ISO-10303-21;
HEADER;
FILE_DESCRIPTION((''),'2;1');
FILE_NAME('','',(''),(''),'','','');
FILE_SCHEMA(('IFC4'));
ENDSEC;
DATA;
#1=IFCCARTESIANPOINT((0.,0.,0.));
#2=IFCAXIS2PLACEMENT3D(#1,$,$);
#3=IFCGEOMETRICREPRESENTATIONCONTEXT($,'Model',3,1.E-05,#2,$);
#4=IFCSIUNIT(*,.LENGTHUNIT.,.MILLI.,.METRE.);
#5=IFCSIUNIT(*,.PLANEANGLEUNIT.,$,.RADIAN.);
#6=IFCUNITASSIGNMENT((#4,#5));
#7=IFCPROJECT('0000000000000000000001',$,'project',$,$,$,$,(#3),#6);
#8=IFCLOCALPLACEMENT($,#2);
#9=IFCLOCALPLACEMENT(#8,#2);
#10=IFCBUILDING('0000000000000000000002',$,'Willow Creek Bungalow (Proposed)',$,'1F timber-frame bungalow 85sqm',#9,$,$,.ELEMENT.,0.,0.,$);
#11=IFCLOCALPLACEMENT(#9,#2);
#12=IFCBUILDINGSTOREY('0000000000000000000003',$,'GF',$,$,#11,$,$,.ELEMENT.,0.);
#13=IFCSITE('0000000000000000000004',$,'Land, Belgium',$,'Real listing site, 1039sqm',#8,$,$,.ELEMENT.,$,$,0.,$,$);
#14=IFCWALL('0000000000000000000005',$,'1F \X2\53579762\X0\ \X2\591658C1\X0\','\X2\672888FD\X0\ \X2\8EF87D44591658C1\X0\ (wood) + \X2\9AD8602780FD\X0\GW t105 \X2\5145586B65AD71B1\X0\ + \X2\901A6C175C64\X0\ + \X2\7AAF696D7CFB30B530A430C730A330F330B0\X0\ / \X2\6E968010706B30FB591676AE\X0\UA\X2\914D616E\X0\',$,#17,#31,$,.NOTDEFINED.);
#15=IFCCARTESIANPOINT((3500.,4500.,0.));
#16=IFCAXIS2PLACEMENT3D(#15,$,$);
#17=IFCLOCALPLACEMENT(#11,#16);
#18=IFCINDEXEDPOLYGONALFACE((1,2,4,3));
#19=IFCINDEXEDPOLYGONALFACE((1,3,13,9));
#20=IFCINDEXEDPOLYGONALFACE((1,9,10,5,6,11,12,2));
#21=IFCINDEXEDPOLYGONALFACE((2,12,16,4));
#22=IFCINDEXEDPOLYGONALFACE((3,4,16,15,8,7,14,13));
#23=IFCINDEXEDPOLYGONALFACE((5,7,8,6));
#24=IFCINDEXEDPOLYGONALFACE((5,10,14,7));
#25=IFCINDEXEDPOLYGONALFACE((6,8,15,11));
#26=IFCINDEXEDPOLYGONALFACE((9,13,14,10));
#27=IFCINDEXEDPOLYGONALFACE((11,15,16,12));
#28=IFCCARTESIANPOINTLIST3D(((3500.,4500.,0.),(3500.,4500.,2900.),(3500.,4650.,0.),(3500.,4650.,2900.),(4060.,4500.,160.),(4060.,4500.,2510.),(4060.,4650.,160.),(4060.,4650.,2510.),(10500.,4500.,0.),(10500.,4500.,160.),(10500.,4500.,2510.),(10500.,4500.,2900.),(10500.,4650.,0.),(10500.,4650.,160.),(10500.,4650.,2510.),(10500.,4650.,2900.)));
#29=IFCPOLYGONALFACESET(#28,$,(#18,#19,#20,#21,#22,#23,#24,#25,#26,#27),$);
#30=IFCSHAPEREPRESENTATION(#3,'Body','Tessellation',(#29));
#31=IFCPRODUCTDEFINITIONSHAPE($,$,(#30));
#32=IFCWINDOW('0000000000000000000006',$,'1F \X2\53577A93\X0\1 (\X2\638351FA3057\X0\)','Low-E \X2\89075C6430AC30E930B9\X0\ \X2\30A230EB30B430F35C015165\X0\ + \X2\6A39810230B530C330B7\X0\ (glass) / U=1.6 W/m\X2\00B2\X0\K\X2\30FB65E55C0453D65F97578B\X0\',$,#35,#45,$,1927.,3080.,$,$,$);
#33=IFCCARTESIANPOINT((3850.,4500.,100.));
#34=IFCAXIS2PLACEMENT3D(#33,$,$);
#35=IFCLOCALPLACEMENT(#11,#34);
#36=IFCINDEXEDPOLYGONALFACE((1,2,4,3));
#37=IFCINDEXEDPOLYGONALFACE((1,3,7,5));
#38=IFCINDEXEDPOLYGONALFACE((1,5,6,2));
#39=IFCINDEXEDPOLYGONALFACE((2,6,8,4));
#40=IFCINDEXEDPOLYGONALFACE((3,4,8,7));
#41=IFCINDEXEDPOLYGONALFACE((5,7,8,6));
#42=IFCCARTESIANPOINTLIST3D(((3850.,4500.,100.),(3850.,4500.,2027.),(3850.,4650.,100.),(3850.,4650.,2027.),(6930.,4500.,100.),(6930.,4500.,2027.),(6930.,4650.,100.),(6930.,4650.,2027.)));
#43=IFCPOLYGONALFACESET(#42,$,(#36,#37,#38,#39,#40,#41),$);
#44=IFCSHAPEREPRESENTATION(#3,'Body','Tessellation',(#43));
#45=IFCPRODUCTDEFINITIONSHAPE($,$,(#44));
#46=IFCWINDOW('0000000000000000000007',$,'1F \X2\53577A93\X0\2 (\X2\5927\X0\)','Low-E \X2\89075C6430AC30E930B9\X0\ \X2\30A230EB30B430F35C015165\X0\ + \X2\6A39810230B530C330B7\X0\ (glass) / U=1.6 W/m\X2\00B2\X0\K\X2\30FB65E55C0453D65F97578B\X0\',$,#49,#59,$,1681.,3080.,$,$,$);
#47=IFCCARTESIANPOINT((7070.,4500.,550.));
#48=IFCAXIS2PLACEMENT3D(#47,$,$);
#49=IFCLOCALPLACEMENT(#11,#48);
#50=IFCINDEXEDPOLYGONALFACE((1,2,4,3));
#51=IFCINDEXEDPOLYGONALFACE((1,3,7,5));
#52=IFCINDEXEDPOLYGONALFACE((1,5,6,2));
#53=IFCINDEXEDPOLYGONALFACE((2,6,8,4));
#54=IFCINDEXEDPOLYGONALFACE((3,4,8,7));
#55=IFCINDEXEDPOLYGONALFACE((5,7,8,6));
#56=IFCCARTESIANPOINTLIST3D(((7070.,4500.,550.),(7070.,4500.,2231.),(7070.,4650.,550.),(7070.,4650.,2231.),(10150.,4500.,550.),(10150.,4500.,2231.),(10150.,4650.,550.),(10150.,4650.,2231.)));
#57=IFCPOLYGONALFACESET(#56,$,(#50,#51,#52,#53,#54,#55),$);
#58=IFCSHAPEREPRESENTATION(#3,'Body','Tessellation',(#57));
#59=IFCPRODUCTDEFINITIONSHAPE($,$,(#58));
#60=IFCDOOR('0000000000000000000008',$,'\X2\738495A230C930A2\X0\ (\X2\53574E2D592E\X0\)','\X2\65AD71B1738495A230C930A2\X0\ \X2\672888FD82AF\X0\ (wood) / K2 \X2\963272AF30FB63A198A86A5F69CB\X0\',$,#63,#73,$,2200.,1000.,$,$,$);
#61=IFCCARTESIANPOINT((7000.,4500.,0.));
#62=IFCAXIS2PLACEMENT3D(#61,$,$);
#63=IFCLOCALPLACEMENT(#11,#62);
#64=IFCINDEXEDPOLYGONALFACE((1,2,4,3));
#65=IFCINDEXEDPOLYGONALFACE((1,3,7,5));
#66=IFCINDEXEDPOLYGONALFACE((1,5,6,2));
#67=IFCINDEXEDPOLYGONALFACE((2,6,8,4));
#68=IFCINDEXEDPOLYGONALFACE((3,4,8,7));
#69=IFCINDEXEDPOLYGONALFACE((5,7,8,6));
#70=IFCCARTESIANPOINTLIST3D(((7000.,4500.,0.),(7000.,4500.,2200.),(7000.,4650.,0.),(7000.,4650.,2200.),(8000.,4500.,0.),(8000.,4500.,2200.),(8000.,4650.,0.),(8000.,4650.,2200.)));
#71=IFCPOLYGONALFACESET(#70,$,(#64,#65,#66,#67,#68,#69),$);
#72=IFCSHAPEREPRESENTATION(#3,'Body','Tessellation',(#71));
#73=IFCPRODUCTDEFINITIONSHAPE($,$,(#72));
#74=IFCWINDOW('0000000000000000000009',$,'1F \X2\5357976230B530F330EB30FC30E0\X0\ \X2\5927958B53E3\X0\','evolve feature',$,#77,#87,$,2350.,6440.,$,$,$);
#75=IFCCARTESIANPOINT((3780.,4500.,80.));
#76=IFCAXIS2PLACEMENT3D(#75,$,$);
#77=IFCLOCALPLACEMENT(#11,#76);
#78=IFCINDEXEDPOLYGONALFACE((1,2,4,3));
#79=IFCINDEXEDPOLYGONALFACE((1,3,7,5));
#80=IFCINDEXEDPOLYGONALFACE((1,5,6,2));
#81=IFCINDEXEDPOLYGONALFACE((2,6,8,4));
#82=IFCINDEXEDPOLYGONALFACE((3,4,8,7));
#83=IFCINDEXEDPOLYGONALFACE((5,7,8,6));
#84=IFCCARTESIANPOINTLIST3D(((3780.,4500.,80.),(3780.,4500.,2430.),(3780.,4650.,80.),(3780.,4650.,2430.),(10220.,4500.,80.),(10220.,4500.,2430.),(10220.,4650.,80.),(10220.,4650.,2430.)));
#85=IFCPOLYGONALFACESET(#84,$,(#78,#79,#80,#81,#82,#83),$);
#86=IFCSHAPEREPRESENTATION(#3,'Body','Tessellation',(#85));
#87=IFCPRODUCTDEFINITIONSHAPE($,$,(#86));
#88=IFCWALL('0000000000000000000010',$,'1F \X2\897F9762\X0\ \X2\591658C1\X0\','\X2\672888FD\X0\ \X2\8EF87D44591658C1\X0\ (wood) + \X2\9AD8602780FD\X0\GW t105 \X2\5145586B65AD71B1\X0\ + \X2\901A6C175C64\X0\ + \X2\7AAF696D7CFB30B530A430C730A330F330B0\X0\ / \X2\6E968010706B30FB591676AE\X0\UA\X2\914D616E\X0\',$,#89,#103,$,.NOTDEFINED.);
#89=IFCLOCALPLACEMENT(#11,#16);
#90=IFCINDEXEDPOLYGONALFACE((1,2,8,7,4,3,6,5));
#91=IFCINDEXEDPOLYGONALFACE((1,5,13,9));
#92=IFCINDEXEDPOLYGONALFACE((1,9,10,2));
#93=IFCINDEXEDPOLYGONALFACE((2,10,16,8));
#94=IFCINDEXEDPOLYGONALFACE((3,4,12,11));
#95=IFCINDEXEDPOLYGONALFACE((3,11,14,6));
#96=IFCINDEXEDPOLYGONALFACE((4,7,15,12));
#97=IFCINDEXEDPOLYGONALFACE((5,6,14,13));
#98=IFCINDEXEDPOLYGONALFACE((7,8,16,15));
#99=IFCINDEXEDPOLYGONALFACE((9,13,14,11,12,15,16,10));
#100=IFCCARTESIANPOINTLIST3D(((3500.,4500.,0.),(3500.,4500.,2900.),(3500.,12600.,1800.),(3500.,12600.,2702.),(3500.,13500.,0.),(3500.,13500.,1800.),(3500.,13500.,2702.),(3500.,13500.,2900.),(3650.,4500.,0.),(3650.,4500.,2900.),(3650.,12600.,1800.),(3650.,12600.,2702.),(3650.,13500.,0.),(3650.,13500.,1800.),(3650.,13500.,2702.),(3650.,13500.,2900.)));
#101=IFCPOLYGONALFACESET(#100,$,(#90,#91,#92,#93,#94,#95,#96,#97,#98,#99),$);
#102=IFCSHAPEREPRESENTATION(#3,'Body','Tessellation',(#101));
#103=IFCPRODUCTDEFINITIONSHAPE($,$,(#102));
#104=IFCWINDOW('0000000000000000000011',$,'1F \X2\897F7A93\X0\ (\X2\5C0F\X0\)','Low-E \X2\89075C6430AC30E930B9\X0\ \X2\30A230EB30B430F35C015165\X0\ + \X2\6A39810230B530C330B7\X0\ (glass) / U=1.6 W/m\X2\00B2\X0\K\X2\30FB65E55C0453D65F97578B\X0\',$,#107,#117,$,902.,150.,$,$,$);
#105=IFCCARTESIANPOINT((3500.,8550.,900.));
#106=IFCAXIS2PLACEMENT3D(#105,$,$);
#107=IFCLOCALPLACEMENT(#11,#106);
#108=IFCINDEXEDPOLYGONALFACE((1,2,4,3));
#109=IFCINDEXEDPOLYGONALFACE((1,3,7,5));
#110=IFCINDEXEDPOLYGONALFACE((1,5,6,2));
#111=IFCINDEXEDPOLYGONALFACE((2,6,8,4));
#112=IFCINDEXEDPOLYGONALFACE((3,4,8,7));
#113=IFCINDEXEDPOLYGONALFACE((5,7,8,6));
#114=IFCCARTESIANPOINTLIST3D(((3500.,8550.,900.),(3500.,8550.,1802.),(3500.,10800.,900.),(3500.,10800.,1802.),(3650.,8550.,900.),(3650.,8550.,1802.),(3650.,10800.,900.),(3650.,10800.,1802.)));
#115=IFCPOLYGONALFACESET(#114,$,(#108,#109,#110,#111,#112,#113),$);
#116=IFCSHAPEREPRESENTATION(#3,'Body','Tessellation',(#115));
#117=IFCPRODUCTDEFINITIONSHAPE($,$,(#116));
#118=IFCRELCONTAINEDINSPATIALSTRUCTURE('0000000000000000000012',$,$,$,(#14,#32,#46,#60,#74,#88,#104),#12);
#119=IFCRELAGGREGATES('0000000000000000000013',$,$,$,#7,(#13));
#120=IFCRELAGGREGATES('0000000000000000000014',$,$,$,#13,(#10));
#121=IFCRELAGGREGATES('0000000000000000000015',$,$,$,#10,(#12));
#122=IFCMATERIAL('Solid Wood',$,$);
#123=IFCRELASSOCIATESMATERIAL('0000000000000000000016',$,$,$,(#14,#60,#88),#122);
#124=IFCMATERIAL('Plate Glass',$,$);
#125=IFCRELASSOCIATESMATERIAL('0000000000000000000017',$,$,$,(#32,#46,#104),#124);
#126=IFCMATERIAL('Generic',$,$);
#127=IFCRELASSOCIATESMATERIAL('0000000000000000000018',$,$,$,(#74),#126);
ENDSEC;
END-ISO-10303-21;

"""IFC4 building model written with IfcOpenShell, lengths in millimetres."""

from ifc_helpers import new_model, si_unit, frame, frame_2d, origin, place, context, project, spatial, rectangle, extrude, material, element, fill, save


model = new_model("IFC4")

# Units and contexts
model_context = context("Model", 3, precision=1e-05, world=origin())
ifc_project = project(units=[si_unit("LENGTHUNIT", "METRE", prefix="MILLI"), si_unit("PLANEANGLEUNIT", "RADIAN")], contexts=[model_context])

# Site, building, storey
site_placement = place(None, origin())
site = spatial("IfcSite", under=ifc_project, at=site_placement, Name="Land, Belgium", ObjectType="Real listing site, 1039sqm", CompositionType="ELEMENT", RefElevation=0.0)
building_placement = place(site_placement, origin())
building = spatial("IfcBuilding", under=site, at=building_placement, Name="Willow Creek Bungalow (Proposed)", ObjectType="1F timber-frame bungalow 85sqm", CompositionType="ELEMENT", ElevationOfRefHeight=0.0, ElevationOfTerrain=0.0)
storey_placement = place(building_placement, origin())
storey = spatial("IfcBuildingStorey", under=building, at=storey_placement, Name="GF", CompositionType="ELEMENT", Elevation=0.0)

# Shared definitions
ifc_material_1 = material(Name="Solid Wood")
ifc_material_2 = material(Name="Generic")

# Wall, openings, windows, door
wall_1_placement = place(storey_placement, frame((3500.0, 4500.0, 0.0)))
wall_1 = element("IfcWall", 1, at=wall_1_placement, inside=storey, material=ifc_material_1, Name="1F 南面 外壁", Description="木製 軸組外壁 (wood) + 高性能GW t105 充填断熱 + 通気層 + 窯業系サイディング / 準耐火・外皮UA配慮", PredefinedType="NOTDEFINED", context=model_context, shape_type="SweptSolid", body=[
    extrude(rectangle(XDim=7000.0, YDim=150.0, at=frame_2d((3500.0, 75.0))), frame((3500.0, 4500.0, 0.0)), (0.0, 0.0, 1.0), 2900.0),
])
opening_1_placement = place(storey_placement, frame((3850.0, 4500.0, 100.0)))
opening_1 = element("IfcOpeningElement", 2, at=opening_1_placement, cuts=wall_1, PredefinedType="NOTDEFINED", context=model_context, shape_type="SweptSolid", body=[
    extrude(rectangle(XDim=3080.0, YDim=150.0, at=frame_2d((1540.0, 75.0))), frame((3850.0, 4500.0, 100.0)), (0.0, 0.0, 1.0), 1927.0),
])
opening_2_placement = place(storey_placement, frame((7070.0, 4500.0, 550.0)))
opening_2 = element("IfcOpeningElement", 3, at=opening_2_placement, cuts=wall_1, PredefinedType="NOTDEFINED", context=model_context, shape_type="SweptSolid", body=[
    extrude(rectangle(XDim=3080.0, YDim=150.0, at=frame_2d((1540.0, 75.0))), frame((7070.0, 4500.0, 550.0)), (0.0, 0.0, 1.0), 1681.0),
])
opening_3_placement = place(storey_placement, frame((7000.0, 4500.0, 0.0)))
opening_3 = element("IfcOpeningElement", 4, at=opening_3_placement, cuts=wall_1, PredefinedType="NOTDEFINED", context=model_context, shape_type="SweptSolid", body=[
    extrude(rectangle(XDim=1000.0, YDim=150.0, at=frame_2d((500.0, 75.0))), frame((7000.0, 4500.0, 0.0)), (0.0, 0.0, 1.0), 2200.0),
])
opening_4_placement = place(storey_placement, frame((3780.0, 4500.0, 80.0)))
opening_4 = element("IfcOpeningElement", 5, at=opening_4_placement, cuts=wall_1, PredefinedType="NOTDEFINED", context=model_context, shape_type="SweptSolid", body=[
    extrude(rectangle(XDim=6440.0, YDim=150.0, at=frame_2d((3220.0, 75.0))), frame((3780.0, 4500.0, 80.0)), (0.0, 0.0, 1.0), 2350.0),
])
ifc_material_3 = material(Name="Plate Glass")
window_1_placement = place(storey_placement, frame((3850.0, 4500.0, 100.0)))
window_1 = element("IfcWindow", 6, at=window_1_placement, inside=storey, material=ifc_material_3, Name="1F 南窓1 (掃出し)", Description="Low-E 複層ガラス アルゴン封入 + 樹脂サッシ (glass) / U=1.6 W/m²K・日射取得型", OverallHeight=1927.0, OverallWidth=3080.0, context=model_context, shape_type="SweptSolid", body=[
    extrude(rectangle(XDim=3080.0, YDim=150.0, at=frame_2d((1540.0, 75.0))), frame((3850.0, 4500.0, 100.0)), (0.0, 0.0, 1.0), 1927.0),
])
fill(opening_1, window_1)
window_2_placement = place(storey_placement, frame((7070.0, 4500.0, 550.0)))
window_2 = element("IfcWindow", 7, at=window_2_placement, inside=storey, material=ifc_material_3, Name="1F 南窓2 (大)", Description="Low-E 複層ガラス アルゴン封入 + 樹脂サッシ (glass) / U=1.6 W/m²K・日射取得型", OverallHeight=1681.0, OverallWidth=3080.0, context=model_context, shape_type="SweptSolid", body=[
    extrude(rectangle(XDim=3080.0, YDim=150.0, at=frame_2d((1540.0, 75.0))), frame((7070.0, 4500.0, 550.0)), (0.0, 0.0, 1.0), 1681.0),
])
fill(opening_2, window_2)
door_placement = place(storey_placement, frame((7000.0, 4500.0, 0.0)))
door = element("IfcDoor", 8, at=door_placement, inside=storey, material=ifc_material_1, Name="玄関ドア (南中央)", Description="断熱玄関ドア 木製芯 (wood) / K2 防犯・採風機構", OverallHeight=2200.0, OverallWidth=1000.0, context=model_context, shape_type="SweptSolid", body=[
    extrude(rectangle(XDim=1000.0, YDim=150.0, at=frame_2d((500.0, 75.0))), frame((7000.0, 4500.0, 0.0)), (0.0, 0.0, 1.0), 2200.0),
])
fill(opening_3, door)
window_3_placement = place(storey_placement, frame((3780.0, 4500.0, 80.0)))
window_3 = element("IfcWindow", 9, at=window_3_placement, inside=storey, material=ifc_material_2, Name="1F 南面サンルーム 大開口", Description="evolve feature", OverallHeight=2350.0, OverallWidth=6440.0, context=model_context, shape_type="SweptSolid", body=[
    extrude(rectangle(XDim=6440.0, YDim=150.0, at=frame_2d((3220.0, 75.0))), frame((3780.0, 4500.0, 80.0)), (0.0, 0.0, 1.0), 2350.0),
])
fill(opening_4, window_3)

# Wall, opening, window
wall_2_placement = place(storey_placement, frame((3500.0, 4500.0, 0.0)))
wall_2 = element("IfcWall", 10, at=wall_2_placement, inside=storey, material=ifc_material_1, Name="1F 西面 外壁", Description="木製 軸組外壁 (wood) + 高性能GW t105 充填断熱 + 通気層 + 窯業系サイディング / 準耐火・外皮UA配慮", PredefinedType="NOTDEFINED", context=model_context, shape_type="SweptSolid", body=[
    extrude(rectangle(XDim=150.0, YDim=9000.0, at=frame_2d((75.0, 4500.0))), frame((3500.0, 4500.0, 0.0)), (0.0, 0.0, 1.0), 2900.0),
])
opening_5_placement = place(storey_placement, frame((3500.0, 8550.0, 900.0)))
opening_5 = element("IfcOpeningElement", 11, at=opening_5_placement, cuts=wall_2, PredefinedType="NOTDEFINED", context=model_context, shape_type="SweptSolid", body=[
    extrude(rectangle(XDim=150.0, YDim=2250.0, at=frame_2d((75.0, 1125.0))), frame((3500.0, 8550.0, 900.0)), (0.0, 0.0, 1.0), 902.0),
])
window_4_placement = place(storey_placement, frame((3500.0, 8550.0, 900.0)))
window_4 = element("IfcWindow", 12, at=window_4_placement, inside=storey, material=ifc_material_3, Name="1F 西窓 (小)", Description="Low-E 複層ガラス アルゴン封入 + 樹脂サッシ (glass) / U=1.6 W/m²K・日射取得型", OverallHeight=902.0, OverallWidth=150.0, context=model_context, shape_type="SweptSolid", body=[
    extrude(rectangle(XDim=150.0, YDim=2250.0, at=frame_2d((75.0, 1125.0))), frame((3500.0, 8550.0, 900.0)), (0.0, 0.0, 1.0), 902.0),
])
fill(opening_5, window_4)

save(model, "model.ifc")
